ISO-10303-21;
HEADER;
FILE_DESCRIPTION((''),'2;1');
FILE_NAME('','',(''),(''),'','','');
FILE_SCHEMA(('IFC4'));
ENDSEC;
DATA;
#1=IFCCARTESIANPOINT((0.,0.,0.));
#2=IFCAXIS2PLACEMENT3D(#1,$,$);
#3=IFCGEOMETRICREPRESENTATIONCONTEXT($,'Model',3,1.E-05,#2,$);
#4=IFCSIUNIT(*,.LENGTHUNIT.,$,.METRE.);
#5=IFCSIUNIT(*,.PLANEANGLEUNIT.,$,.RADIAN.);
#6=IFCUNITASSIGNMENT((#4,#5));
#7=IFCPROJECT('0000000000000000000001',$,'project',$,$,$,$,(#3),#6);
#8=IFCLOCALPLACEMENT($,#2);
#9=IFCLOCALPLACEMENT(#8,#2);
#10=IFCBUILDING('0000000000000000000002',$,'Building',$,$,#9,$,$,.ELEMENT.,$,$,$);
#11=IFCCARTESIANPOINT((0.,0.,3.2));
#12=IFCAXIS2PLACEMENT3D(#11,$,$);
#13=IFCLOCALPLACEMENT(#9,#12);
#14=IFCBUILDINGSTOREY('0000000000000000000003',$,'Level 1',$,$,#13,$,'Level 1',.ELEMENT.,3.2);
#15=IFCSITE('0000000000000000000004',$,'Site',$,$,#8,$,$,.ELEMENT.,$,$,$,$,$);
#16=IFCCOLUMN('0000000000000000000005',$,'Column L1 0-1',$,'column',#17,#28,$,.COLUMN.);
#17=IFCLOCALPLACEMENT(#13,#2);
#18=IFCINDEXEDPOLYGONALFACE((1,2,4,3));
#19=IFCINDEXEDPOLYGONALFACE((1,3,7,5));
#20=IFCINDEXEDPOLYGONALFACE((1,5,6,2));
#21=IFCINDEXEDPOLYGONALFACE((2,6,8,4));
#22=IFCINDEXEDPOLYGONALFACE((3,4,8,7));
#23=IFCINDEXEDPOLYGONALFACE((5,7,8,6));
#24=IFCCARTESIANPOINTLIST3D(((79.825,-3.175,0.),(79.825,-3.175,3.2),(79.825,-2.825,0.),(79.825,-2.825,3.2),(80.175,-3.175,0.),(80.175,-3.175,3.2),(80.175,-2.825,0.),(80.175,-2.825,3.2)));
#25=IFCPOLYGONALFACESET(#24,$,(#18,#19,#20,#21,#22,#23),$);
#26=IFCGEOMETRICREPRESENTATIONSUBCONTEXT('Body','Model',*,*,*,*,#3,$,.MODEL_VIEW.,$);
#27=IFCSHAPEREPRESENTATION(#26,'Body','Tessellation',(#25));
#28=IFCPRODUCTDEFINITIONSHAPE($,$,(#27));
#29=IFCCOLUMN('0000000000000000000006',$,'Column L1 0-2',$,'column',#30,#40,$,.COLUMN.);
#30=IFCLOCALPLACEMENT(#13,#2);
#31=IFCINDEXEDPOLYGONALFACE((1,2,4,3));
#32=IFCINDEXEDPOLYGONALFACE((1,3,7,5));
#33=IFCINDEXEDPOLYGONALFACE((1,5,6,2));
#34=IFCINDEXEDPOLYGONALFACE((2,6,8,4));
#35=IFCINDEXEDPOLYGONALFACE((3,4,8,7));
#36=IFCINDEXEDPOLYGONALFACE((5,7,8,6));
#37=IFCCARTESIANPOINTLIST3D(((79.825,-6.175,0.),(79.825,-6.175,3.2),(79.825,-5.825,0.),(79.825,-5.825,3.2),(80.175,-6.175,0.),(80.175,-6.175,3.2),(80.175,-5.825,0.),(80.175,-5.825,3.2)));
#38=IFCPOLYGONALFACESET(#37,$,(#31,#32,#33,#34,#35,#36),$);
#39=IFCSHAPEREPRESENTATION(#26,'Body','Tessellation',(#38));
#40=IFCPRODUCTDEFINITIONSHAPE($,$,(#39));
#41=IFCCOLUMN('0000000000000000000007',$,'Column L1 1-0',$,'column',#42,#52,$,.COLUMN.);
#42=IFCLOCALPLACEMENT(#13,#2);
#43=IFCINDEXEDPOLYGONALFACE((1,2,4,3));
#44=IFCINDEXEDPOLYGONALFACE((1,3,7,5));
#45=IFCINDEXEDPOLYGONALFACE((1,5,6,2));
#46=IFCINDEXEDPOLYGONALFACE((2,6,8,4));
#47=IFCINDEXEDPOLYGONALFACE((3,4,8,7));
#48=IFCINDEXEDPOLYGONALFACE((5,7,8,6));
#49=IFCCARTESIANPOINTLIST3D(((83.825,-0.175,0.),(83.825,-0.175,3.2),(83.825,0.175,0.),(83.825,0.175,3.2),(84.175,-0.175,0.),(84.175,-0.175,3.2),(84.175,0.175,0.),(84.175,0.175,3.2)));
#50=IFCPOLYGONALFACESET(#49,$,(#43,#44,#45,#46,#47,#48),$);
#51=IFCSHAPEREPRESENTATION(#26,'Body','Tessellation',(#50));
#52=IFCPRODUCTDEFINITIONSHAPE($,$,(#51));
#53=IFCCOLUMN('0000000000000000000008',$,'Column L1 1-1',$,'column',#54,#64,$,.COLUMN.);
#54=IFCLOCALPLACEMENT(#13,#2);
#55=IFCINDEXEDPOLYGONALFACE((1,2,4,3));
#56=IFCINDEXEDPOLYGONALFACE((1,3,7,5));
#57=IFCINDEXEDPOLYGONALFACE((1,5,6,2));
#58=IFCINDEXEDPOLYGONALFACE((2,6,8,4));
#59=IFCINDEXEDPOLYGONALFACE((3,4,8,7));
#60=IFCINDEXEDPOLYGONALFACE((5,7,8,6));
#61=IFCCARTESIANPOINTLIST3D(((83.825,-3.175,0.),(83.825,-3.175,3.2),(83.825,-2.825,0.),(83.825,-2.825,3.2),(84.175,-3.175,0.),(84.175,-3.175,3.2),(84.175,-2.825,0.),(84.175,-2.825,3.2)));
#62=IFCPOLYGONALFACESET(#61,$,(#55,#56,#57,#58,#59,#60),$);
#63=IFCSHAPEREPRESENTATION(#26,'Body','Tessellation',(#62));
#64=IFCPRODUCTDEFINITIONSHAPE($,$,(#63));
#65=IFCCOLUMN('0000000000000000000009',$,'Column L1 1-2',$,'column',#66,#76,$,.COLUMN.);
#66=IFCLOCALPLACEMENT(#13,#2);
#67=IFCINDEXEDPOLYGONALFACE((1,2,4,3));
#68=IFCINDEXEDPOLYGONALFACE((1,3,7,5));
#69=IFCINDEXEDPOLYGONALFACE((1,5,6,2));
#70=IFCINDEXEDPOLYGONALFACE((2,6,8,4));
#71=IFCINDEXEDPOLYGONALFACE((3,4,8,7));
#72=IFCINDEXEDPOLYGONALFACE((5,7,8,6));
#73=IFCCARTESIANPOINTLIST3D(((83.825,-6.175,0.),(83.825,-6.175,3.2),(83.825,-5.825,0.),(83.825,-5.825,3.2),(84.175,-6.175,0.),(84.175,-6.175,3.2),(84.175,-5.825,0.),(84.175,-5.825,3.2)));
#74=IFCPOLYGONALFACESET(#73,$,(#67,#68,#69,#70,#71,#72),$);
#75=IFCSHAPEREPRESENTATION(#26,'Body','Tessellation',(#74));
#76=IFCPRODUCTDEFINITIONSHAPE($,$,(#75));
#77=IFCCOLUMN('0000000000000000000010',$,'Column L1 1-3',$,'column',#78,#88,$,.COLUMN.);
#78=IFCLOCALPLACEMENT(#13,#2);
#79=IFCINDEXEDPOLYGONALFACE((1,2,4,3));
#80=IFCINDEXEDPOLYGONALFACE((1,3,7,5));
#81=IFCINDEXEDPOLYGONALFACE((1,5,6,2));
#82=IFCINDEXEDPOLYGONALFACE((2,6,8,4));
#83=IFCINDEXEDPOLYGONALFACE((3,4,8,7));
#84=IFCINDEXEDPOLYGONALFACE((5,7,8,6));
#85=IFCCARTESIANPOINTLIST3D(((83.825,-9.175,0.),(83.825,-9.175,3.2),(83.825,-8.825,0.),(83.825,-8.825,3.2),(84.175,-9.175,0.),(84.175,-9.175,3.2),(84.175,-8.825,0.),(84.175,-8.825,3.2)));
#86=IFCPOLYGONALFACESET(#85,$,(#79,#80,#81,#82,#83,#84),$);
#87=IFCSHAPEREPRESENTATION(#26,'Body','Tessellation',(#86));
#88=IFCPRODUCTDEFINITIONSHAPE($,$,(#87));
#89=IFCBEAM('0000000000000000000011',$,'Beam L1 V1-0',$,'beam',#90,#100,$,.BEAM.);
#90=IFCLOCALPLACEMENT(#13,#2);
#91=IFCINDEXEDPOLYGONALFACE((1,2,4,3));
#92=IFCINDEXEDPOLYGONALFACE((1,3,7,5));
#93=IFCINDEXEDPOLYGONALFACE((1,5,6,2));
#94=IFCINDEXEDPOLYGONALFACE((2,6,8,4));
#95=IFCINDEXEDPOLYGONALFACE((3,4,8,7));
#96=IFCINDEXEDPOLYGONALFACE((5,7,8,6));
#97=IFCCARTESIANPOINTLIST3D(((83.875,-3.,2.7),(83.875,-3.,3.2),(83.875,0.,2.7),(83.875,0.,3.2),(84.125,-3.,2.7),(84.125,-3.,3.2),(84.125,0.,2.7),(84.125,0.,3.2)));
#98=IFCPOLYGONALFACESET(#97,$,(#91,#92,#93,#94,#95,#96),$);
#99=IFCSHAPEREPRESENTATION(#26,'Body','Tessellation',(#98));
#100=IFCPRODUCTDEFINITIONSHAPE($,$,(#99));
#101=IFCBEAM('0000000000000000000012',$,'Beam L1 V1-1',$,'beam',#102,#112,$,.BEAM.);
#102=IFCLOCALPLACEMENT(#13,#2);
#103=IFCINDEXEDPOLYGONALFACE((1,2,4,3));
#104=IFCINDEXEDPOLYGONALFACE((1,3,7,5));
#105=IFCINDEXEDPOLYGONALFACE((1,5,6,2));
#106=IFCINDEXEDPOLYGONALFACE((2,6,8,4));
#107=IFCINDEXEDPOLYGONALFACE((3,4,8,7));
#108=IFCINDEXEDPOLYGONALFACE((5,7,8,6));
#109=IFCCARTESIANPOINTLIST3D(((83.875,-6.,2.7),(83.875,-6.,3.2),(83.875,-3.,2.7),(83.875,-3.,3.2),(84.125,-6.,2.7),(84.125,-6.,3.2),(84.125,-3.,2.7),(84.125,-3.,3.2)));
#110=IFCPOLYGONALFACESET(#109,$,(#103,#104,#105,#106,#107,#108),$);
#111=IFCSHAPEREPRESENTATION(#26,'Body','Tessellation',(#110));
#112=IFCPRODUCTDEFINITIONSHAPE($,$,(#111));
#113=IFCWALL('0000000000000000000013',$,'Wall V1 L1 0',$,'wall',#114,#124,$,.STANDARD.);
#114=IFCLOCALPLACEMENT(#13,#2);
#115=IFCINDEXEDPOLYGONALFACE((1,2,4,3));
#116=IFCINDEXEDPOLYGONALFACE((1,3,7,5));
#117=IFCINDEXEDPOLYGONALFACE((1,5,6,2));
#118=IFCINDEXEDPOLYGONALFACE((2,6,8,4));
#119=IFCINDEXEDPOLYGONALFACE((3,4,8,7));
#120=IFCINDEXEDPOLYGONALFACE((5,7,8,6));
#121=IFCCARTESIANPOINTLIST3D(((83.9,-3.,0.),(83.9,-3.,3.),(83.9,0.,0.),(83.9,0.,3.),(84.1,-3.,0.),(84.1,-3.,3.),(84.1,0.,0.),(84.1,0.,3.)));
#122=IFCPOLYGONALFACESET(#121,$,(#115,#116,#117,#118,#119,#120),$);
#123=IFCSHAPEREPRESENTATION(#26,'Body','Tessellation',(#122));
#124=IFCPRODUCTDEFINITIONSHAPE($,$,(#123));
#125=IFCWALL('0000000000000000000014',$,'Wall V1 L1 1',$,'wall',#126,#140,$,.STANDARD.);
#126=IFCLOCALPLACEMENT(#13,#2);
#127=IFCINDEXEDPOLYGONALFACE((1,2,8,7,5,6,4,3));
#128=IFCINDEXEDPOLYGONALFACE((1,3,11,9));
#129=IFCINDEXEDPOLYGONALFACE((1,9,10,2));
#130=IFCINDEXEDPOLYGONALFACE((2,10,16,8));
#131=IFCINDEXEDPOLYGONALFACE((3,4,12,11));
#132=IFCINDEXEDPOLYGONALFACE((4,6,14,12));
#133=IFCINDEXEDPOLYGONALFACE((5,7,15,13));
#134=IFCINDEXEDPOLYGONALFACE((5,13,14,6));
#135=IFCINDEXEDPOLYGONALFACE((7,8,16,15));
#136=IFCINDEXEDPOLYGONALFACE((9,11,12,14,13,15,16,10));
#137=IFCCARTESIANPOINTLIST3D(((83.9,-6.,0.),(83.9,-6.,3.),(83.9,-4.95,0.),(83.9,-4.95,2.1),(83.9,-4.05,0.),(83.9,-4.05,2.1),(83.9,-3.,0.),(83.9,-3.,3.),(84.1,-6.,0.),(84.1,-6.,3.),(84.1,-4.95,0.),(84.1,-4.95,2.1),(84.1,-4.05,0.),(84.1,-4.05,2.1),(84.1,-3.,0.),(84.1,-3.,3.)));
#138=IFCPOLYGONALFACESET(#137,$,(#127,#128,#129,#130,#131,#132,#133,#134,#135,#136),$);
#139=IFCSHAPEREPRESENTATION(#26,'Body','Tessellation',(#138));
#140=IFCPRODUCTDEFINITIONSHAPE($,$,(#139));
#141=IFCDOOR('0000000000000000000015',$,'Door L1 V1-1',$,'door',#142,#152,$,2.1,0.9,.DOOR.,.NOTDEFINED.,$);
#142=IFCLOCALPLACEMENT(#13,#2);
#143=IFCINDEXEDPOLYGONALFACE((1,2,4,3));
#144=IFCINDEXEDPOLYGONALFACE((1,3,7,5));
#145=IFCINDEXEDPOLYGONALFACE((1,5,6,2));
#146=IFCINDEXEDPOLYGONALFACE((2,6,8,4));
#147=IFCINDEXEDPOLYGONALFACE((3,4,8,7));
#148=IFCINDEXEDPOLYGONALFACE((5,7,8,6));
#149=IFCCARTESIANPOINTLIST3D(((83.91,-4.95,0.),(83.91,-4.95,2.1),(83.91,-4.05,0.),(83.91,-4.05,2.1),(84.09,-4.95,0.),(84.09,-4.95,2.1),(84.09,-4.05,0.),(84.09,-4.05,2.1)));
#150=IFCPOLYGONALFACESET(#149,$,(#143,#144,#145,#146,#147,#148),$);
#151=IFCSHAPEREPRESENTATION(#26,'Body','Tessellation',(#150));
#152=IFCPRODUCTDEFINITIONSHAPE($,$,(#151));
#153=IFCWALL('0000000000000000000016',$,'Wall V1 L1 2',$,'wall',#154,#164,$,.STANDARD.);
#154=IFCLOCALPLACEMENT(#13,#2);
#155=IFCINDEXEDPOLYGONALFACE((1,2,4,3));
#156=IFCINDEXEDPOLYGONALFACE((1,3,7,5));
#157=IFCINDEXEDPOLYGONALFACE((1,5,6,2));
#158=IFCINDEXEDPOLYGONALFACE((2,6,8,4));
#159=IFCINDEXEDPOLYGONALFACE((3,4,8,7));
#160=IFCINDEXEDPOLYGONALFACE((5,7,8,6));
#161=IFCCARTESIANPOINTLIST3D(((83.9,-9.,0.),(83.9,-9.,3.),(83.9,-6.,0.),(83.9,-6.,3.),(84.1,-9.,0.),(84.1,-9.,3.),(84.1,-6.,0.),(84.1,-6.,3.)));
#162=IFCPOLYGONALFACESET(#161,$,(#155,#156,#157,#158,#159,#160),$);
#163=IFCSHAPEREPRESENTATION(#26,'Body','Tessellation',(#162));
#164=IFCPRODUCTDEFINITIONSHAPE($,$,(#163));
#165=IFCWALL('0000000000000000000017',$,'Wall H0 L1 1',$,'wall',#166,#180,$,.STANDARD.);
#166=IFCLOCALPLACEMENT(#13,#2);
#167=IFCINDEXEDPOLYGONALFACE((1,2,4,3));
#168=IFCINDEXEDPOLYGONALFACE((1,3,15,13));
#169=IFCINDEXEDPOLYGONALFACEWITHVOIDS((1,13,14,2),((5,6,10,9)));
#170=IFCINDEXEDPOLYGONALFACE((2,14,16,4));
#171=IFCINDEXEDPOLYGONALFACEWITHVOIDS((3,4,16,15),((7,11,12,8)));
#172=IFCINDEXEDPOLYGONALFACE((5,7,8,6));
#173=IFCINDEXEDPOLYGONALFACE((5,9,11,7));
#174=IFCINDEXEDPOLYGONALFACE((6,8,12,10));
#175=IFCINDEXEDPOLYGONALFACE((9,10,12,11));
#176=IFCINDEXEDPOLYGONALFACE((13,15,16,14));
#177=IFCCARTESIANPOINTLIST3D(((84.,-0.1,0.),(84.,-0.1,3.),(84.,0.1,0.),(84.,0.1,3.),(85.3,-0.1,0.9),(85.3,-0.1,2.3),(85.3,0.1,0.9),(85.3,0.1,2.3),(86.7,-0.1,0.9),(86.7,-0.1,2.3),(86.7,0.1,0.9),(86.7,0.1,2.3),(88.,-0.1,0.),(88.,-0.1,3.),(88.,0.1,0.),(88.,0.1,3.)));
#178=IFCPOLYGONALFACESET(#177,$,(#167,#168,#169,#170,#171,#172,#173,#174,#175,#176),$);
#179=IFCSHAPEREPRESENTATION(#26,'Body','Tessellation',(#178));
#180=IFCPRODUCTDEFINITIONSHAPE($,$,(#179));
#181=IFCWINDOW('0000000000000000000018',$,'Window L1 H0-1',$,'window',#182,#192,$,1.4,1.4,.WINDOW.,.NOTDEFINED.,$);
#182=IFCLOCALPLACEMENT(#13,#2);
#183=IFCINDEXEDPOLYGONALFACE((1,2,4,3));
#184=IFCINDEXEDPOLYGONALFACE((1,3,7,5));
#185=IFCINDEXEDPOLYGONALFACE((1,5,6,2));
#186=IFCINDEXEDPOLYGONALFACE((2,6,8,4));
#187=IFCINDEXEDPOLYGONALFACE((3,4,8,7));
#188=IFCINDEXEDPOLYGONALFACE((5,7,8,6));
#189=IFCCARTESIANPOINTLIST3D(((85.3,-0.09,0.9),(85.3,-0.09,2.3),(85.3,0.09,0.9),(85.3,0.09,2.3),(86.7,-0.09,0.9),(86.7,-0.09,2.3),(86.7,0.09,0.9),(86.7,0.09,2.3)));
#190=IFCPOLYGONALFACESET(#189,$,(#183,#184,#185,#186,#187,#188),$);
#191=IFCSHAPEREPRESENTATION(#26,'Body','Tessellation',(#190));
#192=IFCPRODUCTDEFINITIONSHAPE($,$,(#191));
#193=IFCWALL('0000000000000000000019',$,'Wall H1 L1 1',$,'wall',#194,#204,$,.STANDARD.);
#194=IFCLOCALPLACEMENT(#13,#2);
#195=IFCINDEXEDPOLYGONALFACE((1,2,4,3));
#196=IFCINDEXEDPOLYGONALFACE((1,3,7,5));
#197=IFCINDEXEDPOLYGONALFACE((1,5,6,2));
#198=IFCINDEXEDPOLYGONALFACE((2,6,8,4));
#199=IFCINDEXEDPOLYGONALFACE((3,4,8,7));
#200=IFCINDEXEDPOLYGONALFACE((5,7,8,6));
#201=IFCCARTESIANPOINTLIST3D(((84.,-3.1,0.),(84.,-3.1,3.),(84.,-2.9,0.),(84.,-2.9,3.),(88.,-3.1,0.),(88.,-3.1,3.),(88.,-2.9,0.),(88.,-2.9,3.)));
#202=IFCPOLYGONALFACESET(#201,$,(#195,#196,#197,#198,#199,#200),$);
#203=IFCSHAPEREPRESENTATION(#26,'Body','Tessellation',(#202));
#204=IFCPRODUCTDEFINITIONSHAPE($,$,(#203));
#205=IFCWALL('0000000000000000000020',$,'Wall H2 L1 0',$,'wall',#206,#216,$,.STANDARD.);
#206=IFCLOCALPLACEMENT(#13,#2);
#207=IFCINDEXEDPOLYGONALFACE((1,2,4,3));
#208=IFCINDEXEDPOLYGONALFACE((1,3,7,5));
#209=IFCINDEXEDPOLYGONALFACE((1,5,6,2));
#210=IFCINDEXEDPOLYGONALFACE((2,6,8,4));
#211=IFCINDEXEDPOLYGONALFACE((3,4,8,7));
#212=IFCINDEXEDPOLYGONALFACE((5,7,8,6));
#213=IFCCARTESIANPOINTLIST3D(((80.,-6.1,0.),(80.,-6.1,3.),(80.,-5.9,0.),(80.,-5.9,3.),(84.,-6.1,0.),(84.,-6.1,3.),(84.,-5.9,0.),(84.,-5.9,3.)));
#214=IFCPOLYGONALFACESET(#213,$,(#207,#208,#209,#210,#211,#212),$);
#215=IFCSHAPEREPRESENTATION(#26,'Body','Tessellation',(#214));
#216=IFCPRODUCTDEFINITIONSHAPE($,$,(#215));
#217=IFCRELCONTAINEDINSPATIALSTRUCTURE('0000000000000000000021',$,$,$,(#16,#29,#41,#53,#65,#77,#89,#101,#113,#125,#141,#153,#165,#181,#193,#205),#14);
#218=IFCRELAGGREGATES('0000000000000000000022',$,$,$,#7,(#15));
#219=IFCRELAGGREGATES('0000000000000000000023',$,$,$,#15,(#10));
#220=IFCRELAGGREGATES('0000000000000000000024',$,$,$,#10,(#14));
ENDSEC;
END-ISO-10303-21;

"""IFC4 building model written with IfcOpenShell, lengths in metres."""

from ifc_helpers import new_model, si_unit, frame, frame_2d, origin, origin_2d, place, context, subcontext, project, spatial, rectangle, extrude, element, fill, save


model = new_model("IFC4")

# Units and contexts
model_context = context("Model", 3, precision=1e-05, world=origin())
body_context = subcontext(model_context, "Body", "Model", "MODEL_VIEW")
ifc_project = project(units=[si_unit("LENGTHUNIT", "METRE"), si_unit("PLANEANGLEUNIT", "RADIAN")], contexts=[model_context])

# Site, building, storey
site_placement = place(None, origin())
site = spatial("IfcSite", under=ifc_project, at=site_placement, Name="Site", CompositionType="ELEMENT")
building_placement = place(site_placement, origin())
building = spatial("IfcBuilding", under=site, at=building_placement, Name="Building", CompositionType="ELEMENT")
storey_placement = place(building_placement, frame((0.0, 0.0, 3.2)))
storey = spatial("IfcBuildingStorey", under=building, at=storey_placement, Name="Level 1", LongName="Level 1", CompositionType="ELEMENT", Elevation=3.2)

# Columns
for number, where, name in (
    (1, (80.0, -3.0, 0.0), "Column L1 0-1"),
    (2, (80.0, -6.0, 0.0), "Column L1 0-2"),
    (3, (84.0, 0.0, 0.0), "Column L1 1-0"),
    (4, (84.0, -3.0, 0.0), "Column L1 1-1"),
    (5, (84.0, -6.0, 0.0), "Column L1 1-2"),
    (6, (84.0, -9.0, 0.0), "Column L1 1-3"),
):
    element("IfcColumn", number, at=place(storey_placement, frame(where)), inside=storey, Name=name, ObjectType="column", PredefinedType="COLUMN", context=body_context, shape_type="SweptSolid", body=[
        extrude(rectangle(XDim=0.35, YDim=0.35, at=origin_2d()), origin(), (0.0, 0.0, 1.0), 3.2),
    ])

# Beams
for number, where, z_axis, x_axis, name in (
    (7, (84.0, 0.0, 2.95), (0.0, -1.0, 0.0), (0.0, 0.0, 1.0), "Beam L1 V1-0"),
    (8, (84.0, -3.0, 2.95), (0.0, -1.0, 0.0), (0.0, 0.0, 1.0), "Beam L1 V1-1"),
):
    element("IfcBeam", number, at=place(storey_placement, frame(where, z_axis=z_axis, x_axis=x_axis)), inside=storey, Name=name, ObjectType="beam", PredefinedType="BEAM", context=body_context, shape_type="SweptSolid", body=[
        extrude(rectangle(XDim=0.5, YDim=0.25, at=origin_2d()), origin(), (0.0, 0.0, 1.0), 3.0),
    ])

# Wall
wall_1_placement = place(storey_placement, frame((84.0, 0.0, 0.0), z_axis=(0.0, 0.0, 1.0), x_axis=(0.0, -1.0, 0.0)))
element("IfcWall", 9, at=wall_1_placement, inside=storey, Name="Wall V1 L1 0", ObjectType="wall", PredefinedType="STANDARD", context=body_context, shape_type="SweptSolid", body=[
    extrude(rectangle(XDim=3.0, YDim=0.2, at=frame_2d((1.5, 0.0))), origin(), (0.0, 0.0, 1.0), 3.0),
])

# Wall, opening, door
wall_2_placement = place(storey_placement, frame((84.0, -3.0, 0.0), z_axis=(0.0, 0.0, 1.0), x_axis=(0.0, -1.0, 0.0)))
wall_2 = element("IfcWall", 10, at=wall_2_placement, inside=storey, Name="Wall V1 L1 1", ObjectType="wall", PredefinedType="STANDARD", context=body_context, shape_type="SweptSolid", body=[
    extrude(rectangle(XDim=3.0, YDim=0.2, at=frame_2d((1.5, 0.0))), origin(), (0.0, 0.0, 1.0), 3.0),
])
opening_1_placement = place(storey_placement, frame((84.0, -4.5, 0.0), z_axis=(0.0, 0.0, 1.0), x_axis=(0.0, -1.0, 0.0)))
opening_1 = element("IfcOpeningElement", 11, at=opening_1_placement, cuts=wall_2, ObjectType="Opening", PredefinedType="OPENING", context=body_context, shape_type="SweptSolid", body=[
    extrude(rectangle(XDim=0.9, YDim=0.22, at=origin_2d()), origin(), (0.0, 0.0, 1.0), 2.1),
])
door_placement = place(storey_placement, frame((84.0, -4.5, 0.0), z_axis=(0.0, 0.0, 1.0), x_axis=(0.0, -1.0, 0.0)))
door = element("IfcDoor", 12, at=door_placement, inside=storey, Name="Door L1 V1-1", ObjectType="door", OperationType="NOTDEFINED", OverallHeight=2.1, OverallWidth=0.9, PredefinedType="DOOR", context=body_context, shape_type="SweptSolid", body=[
    extrude(rectangle(XDim=0.9, YDim=0.18, at=origin_2d()), origin(), (0.0, 0.0, 1.0), 2.1),
])
fill(opening_1, door)

# Wall
wall_3_placement = place(storey_placement, frame((84.0, -6.0, 0.0), z_axis=(0.0, 0.0, 1.0), x_axis=(0.0, -1.0, 0.0)))
element("IfcWall", 13, at=wall_3_placement, inside=storey, Name="Wall V1 L1 2", ObjectType="wall", PredefinedType="STANDARD", context=body_context, shape_type="SweptSolid", body=[
    extrude(rectangle(XDim=3.0, YDim=0.2, at=frame_2d((1.5, 0.0))), origin(), (0.0, 0.0, 1.0), 3.0),
])

# Wall, opening, window
wall_4_placement = place(storey_placement, frame((84.0, 0.0, 0.0), z_axis=(0.0, 0.0, 1.0), x_axis=(1.0, 0.0, 0.0)))
wall_4 = element("IfcWall", 14, at=wall_4_placement, inside=storey, Name="Wall H0 L1 1", ObjectType="wall", PredefinedType="STANDARD", context=body_context, shape_type="SweptSolid", body=[
    extrude(rectangle(XDim=4.0, YDim=0.2, at=frame_2d((2.0, 0.0))), origin(), (0.0, 0.0, 1.0), 3.0),
])
opening_2_placement = place(storey_placement, frame((86.0, 0.0, 0.9), z_axis=(0.0, 0.0, 1.0), x_axis=(1.0, 0.0, 0.0)))
opening_2 = element("IfcOpeningElement", 15, at=opening_2_placement, cuts=wall_4, ObjectType="Opening", PredefinedType="OPENING", context=body_context, shape_type="SweptSolid", body=[
    extrude(rectangle(XDim=1.4, YDim=0.22, at=origin_2d()), origin(), (0.0, 0.0, 1.0), 1.4),
])
window_1_placement = place(storey_placement, frame((86.0, 0.0, 0.9), z_axis=(0.0, 0.0, 1.0), x_axis=(1.0, 0.0, 0.0)))
window_1 = element("IfcWindow", 16, at=window_1_placement, inside=storey, Name="Window L1 H0-1", ObjectType="window", OverallHeight=1.4, OverallWidth=1.4, PartitioningType="NOTDEFINED", PredefinedType="WINDOW", context=body_context, shape_type="SweptSolid", body=[
    extrude(rectangle(XDim=1.4, YDim=0.18, at=origin_2d()), origin(), (0.0, 0.0, 1.0), 1.4),
])
fill(opening_2, window_1)

# Walls
for number, where, z_axis, x_axis, name in (
    (17, (84.0, -3.0, 0.0), (0.0, 0.0, 1.0), (1.0, 0.0, 0.0), "Wall H1 L1 1"),
    (18, (80.0, -6.0, 0.0), (0.0, 0.0, 1.0), (1.0, 0.0, 0.0), "Wall H2 L1 0"),
):
    element("IfcWall", number, at=place(storey_placement, frame(where, z_axis=z_axis, x_axis=x_axis)), inside=storey, Name=name, ObjectType="wall", PredefinedType="STANDARD", context=body_context, shape_type="SweptSolid", body=[
        extrude(rectangle(XDim=4.0, YDim=0.2, at=frame_2d((2.0, 0.0))), origin(), (0.0, 0.0, 1.0), 3.0),
    ])

save(model, "model.ifc")
